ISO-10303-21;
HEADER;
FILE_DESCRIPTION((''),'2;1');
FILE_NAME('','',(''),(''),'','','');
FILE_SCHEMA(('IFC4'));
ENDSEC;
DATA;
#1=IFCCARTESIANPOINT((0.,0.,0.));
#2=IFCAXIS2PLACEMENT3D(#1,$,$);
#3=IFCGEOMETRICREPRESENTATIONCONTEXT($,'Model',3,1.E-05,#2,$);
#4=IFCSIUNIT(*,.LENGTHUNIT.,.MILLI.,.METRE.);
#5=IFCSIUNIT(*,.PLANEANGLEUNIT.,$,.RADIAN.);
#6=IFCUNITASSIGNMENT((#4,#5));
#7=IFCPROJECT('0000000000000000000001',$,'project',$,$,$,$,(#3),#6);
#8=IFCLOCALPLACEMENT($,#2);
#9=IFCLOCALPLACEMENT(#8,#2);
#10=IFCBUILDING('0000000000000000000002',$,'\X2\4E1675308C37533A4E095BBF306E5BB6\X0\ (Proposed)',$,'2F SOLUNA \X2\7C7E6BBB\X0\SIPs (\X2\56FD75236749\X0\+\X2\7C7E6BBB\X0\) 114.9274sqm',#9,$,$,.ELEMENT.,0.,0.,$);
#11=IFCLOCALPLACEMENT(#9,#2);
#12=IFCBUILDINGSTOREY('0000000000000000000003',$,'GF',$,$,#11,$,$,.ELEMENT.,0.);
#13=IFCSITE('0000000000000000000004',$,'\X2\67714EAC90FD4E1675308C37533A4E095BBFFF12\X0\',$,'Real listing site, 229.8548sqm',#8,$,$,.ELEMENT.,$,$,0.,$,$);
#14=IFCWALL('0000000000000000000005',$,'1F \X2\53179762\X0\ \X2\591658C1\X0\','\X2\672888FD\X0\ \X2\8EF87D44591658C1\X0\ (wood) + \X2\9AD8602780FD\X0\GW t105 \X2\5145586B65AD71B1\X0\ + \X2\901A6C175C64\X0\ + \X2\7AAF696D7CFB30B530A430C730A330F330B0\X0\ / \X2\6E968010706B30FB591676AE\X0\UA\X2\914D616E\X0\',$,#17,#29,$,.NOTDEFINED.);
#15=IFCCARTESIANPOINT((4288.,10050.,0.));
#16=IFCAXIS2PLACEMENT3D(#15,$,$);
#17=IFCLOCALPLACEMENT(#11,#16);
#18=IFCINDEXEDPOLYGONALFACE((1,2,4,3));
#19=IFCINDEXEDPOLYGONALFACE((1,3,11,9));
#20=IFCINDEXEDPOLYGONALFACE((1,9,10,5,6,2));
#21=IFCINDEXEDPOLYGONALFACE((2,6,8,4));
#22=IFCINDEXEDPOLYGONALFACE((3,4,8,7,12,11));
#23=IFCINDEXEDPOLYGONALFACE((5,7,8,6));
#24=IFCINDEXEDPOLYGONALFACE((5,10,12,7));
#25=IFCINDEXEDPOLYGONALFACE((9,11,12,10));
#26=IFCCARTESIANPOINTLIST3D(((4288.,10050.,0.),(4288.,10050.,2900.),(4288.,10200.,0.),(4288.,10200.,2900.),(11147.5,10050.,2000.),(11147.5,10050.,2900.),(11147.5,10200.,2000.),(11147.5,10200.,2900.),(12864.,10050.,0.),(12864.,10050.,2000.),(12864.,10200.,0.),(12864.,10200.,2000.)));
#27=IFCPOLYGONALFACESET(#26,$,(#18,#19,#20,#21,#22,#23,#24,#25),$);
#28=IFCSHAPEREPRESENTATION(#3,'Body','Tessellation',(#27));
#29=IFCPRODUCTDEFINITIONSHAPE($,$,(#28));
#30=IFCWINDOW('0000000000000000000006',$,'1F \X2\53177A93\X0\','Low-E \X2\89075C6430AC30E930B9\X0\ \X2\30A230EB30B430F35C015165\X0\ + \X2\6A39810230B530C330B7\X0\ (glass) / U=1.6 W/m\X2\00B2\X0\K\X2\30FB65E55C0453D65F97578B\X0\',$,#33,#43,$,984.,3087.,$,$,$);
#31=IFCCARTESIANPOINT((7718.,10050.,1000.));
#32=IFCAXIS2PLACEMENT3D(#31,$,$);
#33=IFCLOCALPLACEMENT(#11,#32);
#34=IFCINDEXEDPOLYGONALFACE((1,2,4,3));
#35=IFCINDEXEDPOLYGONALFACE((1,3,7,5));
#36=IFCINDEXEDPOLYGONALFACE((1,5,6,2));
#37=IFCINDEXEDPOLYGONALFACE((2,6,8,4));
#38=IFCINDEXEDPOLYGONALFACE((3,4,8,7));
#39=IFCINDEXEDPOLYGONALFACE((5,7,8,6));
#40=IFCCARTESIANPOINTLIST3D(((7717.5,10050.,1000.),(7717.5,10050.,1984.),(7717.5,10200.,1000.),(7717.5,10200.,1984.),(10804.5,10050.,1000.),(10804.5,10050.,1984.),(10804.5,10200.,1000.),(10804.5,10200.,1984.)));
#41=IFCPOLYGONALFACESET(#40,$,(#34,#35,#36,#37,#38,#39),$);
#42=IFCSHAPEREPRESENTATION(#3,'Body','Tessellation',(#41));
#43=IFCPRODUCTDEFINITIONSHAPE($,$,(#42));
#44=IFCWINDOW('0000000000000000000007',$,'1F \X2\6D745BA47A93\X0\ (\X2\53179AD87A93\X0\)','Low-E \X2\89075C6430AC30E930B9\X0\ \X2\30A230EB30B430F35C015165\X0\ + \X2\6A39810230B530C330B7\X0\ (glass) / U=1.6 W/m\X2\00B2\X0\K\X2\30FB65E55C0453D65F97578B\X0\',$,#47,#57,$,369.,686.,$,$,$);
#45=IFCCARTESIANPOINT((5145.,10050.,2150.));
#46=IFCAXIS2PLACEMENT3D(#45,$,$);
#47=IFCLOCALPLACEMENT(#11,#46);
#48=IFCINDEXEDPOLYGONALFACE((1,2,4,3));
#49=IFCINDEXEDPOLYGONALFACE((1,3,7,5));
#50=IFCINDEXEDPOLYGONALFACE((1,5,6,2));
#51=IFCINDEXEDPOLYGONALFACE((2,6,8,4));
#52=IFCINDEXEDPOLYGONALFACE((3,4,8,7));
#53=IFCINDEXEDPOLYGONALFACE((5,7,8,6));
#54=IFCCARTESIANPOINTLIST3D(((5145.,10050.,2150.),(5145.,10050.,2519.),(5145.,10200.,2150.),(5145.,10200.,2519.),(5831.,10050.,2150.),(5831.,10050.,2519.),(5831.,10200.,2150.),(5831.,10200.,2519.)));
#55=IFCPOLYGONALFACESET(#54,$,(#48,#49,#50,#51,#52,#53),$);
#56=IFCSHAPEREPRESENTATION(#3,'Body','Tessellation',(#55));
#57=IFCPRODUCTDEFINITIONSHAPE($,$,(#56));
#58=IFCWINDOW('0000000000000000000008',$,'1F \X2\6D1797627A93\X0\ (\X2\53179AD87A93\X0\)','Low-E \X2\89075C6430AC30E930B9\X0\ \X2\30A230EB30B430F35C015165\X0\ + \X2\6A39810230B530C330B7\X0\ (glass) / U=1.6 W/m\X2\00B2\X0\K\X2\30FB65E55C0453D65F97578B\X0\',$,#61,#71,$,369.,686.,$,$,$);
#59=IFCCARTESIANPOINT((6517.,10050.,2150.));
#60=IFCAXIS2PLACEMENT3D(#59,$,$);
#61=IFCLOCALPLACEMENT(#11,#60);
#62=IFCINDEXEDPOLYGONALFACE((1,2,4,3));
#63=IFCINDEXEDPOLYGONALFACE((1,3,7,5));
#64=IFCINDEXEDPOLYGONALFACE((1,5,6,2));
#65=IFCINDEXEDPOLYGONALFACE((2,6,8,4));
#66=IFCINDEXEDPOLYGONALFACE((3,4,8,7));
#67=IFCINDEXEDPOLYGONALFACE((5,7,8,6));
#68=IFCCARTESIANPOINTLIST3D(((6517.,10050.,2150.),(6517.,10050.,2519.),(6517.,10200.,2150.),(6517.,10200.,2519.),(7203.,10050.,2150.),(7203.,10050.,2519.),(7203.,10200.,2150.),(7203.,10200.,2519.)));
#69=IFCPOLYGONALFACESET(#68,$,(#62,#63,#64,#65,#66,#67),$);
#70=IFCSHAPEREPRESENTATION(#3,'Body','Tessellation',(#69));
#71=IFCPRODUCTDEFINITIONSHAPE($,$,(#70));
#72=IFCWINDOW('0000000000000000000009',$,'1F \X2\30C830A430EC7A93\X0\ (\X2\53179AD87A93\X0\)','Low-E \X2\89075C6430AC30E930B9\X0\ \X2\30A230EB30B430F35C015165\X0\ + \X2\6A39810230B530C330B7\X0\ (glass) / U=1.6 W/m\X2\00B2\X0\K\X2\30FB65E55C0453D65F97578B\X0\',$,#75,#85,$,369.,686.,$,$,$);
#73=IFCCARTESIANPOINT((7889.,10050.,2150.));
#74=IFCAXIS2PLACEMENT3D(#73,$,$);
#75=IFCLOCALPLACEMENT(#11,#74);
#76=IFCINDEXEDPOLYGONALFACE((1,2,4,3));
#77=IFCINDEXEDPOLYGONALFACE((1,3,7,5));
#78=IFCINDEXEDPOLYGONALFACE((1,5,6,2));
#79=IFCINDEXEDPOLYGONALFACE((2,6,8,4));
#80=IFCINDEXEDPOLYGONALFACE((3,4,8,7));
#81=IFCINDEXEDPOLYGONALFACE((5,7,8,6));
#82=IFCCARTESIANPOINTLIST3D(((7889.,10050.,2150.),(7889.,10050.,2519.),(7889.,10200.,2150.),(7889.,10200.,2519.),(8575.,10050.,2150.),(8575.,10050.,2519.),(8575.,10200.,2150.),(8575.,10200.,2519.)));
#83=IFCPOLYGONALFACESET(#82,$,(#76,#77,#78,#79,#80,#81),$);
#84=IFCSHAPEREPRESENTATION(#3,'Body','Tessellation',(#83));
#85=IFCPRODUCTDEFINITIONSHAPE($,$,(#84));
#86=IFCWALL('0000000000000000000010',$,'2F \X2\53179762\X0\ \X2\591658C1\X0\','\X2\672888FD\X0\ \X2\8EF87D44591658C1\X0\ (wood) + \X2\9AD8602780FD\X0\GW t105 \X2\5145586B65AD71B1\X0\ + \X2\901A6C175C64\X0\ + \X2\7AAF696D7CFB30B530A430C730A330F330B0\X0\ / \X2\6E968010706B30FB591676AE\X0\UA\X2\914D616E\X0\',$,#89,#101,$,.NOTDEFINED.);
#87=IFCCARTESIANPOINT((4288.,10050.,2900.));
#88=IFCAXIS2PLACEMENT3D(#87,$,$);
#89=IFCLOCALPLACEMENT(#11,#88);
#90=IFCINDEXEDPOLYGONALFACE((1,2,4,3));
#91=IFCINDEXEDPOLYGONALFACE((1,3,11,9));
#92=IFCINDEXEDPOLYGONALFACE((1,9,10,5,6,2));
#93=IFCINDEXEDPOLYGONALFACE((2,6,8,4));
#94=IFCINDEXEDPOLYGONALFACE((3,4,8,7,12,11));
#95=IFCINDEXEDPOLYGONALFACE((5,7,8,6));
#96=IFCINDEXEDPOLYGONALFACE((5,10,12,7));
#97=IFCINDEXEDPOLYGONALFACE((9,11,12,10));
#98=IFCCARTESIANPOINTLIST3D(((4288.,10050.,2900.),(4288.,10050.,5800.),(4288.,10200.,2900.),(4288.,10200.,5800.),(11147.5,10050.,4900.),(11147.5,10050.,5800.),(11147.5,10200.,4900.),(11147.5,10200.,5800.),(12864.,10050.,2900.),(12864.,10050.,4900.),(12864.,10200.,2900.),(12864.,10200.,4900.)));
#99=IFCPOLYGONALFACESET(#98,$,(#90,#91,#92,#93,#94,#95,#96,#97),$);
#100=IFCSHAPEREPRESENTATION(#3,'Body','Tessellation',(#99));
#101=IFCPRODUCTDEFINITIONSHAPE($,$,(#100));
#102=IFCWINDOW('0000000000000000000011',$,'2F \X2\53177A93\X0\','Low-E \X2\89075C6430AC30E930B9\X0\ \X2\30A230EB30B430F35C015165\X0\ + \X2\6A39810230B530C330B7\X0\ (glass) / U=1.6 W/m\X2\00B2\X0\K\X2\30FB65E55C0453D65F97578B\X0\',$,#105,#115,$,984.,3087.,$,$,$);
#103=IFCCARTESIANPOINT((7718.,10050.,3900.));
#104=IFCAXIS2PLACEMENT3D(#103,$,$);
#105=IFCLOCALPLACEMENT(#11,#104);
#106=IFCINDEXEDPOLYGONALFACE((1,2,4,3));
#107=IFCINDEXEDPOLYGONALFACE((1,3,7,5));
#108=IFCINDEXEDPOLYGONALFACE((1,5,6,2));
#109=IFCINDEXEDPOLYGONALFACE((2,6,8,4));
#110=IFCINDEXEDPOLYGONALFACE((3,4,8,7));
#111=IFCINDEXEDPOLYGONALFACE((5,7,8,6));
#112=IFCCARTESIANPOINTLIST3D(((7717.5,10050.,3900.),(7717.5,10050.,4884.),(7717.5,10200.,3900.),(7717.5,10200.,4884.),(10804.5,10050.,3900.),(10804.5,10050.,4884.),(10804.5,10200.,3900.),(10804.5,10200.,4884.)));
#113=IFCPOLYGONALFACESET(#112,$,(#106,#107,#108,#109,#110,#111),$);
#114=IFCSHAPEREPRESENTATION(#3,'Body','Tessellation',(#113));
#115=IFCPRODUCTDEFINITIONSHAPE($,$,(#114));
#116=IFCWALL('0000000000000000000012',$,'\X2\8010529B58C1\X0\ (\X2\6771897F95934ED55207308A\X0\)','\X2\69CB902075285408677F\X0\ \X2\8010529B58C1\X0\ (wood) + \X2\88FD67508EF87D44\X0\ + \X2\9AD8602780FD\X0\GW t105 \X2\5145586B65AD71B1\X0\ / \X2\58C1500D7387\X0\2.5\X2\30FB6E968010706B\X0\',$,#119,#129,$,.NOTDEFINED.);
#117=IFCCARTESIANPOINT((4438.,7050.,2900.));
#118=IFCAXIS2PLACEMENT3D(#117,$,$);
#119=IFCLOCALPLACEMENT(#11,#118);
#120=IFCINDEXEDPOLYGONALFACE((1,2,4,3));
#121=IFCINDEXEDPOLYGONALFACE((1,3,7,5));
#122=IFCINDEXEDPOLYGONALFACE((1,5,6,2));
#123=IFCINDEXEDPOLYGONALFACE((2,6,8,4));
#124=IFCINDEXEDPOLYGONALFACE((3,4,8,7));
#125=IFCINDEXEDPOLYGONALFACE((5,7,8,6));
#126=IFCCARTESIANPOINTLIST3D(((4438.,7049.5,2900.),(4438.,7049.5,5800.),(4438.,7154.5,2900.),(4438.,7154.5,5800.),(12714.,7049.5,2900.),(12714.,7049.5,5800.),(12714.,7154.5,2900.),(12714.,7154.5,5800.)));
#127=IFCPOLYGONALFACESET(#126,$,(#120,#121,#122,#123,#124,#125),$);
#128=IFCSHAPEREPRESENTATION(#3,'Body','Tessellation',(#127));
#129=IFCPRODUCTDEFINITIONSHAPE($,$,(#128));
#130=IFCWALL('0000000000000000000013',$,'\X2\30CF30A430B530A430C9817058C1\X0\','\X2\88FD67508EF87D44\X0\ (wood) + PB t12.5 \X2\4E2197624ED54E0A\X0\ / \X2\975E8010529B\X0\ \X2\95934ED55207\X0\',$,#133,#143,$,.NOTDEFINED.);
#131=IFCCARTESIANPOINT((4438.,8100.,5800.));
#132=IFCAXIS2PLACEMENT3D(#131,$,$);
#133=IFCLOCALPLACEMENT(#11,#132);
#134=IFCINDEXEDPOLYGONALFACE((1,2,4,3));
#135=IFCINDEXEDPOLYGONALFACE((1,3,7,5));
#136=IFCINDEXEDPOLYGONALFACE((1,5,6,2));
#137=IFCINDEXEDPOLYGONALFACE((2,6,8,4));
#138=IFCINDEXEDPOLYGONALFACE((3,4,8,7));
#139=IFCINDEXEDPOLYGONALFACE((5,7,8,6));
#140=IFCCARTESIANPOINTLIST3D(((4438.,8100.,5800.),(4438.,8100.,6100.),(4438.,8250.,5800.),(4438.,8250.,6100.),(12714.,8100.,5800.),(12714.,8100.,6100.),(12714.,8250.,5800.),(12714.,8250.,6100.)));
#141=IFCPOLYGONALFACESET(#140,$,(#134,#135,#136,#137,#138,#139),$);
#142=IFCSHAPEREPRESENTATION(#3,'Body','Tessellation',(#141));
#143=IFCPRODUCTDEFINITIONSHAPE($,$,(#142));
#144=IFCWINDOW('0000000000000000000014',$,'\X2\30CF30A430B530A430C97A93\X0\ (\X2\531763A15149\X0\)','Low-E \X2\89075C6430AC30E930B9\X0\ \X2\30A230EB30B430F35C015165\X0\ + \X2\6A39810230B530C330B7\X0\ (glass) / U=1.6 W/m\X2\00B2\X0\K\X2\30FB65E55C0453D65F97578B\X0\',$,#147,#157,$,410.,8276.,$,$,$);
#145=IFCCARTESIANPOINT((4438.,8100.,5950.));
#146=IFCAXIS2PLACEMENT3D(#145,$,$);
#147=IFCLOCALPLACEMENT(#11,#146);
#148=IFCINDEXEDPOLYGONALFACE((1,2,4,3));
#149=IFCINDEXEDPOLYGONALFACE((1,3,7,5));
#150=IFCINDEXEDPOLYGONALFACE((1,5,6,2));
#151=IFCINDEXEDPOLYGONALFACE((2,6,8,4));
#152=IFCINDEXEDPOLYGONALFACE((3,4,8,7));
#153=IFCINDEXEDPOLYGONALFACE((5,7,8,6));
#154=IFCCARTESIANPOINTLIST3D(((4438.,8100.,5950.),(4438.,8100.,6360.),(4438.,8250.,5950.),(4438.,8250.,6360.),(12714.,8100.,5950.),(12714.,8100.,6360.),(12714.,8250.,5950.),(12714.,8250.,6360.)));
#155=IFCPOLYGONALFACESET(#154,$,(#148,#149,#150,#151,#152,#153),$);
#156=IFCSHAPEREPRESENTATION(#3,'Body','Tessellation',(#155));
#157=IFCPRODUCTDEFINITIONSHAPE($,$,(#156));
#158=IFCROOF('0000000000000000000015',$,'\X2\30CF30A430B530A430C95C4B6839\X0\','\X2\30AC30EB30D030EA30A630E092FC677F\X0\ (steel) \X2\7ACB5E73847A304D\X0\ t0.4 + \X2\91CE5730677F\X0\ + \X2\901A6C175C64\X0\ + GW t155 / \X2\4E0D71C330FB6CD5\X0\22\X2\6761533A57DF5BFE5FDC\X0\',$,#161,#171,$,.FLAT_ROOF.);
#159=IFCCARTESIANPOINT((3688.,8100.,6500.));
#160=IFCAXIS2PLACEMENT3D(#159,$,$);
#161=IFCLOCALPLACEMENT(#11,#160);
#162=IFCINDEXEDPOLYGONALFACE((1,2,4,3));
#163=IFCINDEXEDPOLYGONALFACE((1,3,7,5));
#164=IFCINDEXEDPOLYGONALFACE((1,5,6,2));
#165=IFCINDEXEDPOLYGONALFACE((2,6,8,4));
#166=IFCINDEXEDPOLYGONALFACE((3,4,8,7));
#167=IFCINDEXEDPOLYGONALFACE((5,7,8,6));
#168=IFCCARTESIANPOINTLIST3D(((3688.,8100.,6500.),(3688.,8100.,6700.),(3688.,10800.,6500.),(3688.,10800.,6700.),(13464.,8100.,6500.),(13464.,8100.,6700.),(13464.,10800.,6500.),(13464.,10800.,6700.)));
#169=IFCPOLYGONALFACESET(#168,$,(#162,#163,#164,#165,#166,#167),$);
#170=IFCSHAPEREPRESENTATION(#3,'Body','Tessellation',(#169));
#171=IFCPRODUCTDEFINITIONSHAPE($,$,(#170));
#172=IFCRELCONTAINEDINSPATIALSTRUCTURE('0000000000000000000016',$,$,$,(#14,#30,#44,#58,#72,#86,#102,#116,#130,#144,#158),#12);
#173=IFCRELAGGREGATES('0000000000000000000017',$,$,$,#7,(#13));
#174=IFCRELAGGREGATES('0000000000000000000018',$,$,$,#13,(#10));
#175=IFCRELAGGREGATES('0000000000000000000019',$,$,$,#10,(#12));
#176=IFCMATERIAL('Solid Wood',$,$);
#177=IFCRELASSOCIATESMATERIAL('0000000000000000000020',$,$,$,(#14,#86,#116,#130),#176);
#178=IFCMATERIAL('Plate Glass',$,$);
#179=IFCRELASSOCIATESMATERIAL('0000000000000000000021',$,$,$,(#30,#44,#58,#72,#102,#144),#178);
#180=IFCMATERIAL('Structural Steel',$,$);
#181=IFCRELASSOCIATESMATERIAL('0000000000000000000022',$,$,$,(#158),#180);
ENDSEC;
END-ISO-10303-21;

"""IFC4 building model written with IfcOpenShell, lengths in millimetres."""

from ifc_helpers import new_model, si_unit, frame, frame_2d, origin, place, context, project, spatial, rectangle, extrude, material, element, fill, save


model = new_model("IFC4")

# Units and contexts
model_context = context("Model", 3, precision=1e-05, world=origin())
ifc_project = project(units=[si_unit("LENGTHUNIT", "METRE", prefix="MILLI"), si_unit("PLANEANGLEUNIT", "RADIAN")], contexts=[model_context])

# Site, building, storey
site_placement = place(None, origin())
site = spatial("IfcSite", under=ifc_project, at=site_placement, Name="東京都世田谷区三宿２", ObjectType="Real listing site, 229.8548sqm", CompositionType="ELEMENT", RefElevation=0.0)
building_placement = place(site_placement, origin())
building = spatial("IfcBuilding", under=site, at=building_placement, Name="世田谷区三宿の家 (Proposed)", ObjectType="2F SOLUNA 籾殻SIPs (国産杉+籾殻) 114.9274sqm", CompositionType="ELEMENT", ElevationOfRefHeight=0.0, ElevationOfTerrain=0.0)
storey_placement = place(building_placement, origin())
storey = spatial("IfcBuildingStorey", under=building, at=storey_placement, Name="GF", CompositionType="ELEMENT", Elevation=0.0)

# Wall, openings, windows
ifc_material_1 = material(Name="Solid Wood")
wall_1_placement = place(storey_placement, frame((4288.0, 10050.0, 0.0)))
wall_1 = element("IfcWall", 1, at=wall_1_placement, inside=storey, material=ifc_material_1, Name="1F 北面 外壁", Description="木製 軸組外壁 (wood) + 高性能GW t105 充填断熱 + 通気層 + 窯業系サイディング / 準耐火・外皮UA配慮", PredefinedType="NOTDEFINED", context=model_context, shape_type="SweptSolid", body=[
    extrude(rectangle(XDim=8576.0, YDim=150.0, at=frame_2d((4288.0, 75.0))), frame((4288.0, 10050.0, 0.0)), (0.0, 0.0, 1.0), 2900.0),
])
opening_1_placement = place(storey_placement, frame((7718.0, 10050.0, 1000.0)))
opening_1 = element("IfcOpeningElement", 2, at=opening_1_placement, cuts=wall_1, PredefinedType="NOTDEFINED", context=model_context, shape_type="SweptSolid", body=[
    extrude(rectangle(XDim=3087.0, YDim=150.0, at=frame_2d((1543.0, 75.0))), frame((7718.0, 10050.0, 1000.0)), (0.0, 0.0, 1.0), 984.0),
])
opening_2_placement = place(storey_placement, frame((5145.0, 10050.0, 2150.0)))
opening_2 = element("IfcOpeningElement", 3, at=opening_2_placement, cuts=wall_1, PredefinedType="NOTDEFINED", context=model_context, shape_type="SweptSolid", body=[
    extrude(rectangle(XDim=686.0, YDim=150.0, at=frame_2d((343.0, 75.0))), frame((5145.0, 10050.0, 2150.0)), (0.0, 0.0, 1.0), 369.0),
])
opening_3_placement = place(storey_placement, frame((6517.0, 10050.0, 2150.0)))
opening_3 = element("IfcOpeningElement", 4, at=opening_3_placement, cuts=wall_1, PredefinedType="NOTDEFINED", context=model_context, shape_type="SweptSolid", body=[
    extrude(rectangle(XDim=686.0, YDim=150.0, at=frame_2d((343.0, 75.0))), frame((6517.0, 10050.0, 2150.0)), (0.0, 0.0, 1.0), 369.0),
])
opening_4_placement = place(storey_placement, frame((7889.0, 10050.0, 2150.0)))
opening_4 = element("IfcOpeningElement", 5, at=opening_4_placement, cuts=wall_1, PredefinedType="NOTDEFINED", context=model_context, shape_type="SweptSolid", body=[
    extrude(rectangle(XDim=686.0, YDim=150.0, at=frame_2d((343.0, 75.0))), frame((7889.0, 10050.0, 2150.0)), (0.0, 0.0, 1.0), 369.0),
])
ifc_material_2 = material(Name="Plate Glass")
window_1_placement = place(storey_placement, frame((7718.0, 10050.0, 1000.0)))
window_1 = element("IfcWindow", 6, at=window_1_placement, inside=storey, material=ifc_material_2, Name="1F 北窓", Description="Low-E 複層ガラス アルゴン封入 + 樹脂サッシ (glass) / U=1.6 W/m²K・日射取得型", OverallHeight=984.0, OverallWidth=3087.0, context=model_context, shape_type="SweptSolid", body=[
    extrude(rectangle(XDim=3087.0, YDim=150.0, at=frame_2d((1543.0, 75.0))), frame((7718.0, 10050.0, 1000.0)), (0.0, 0.0, 1.0), 984.0),
])
fill(opening_1, window_1)
window_2_placement = place(storey_placement, frame((5145.0, 10050.0, 2150.0)))
window_2 = element("IfcWindow", 7, at=window_2_placement, inside=storey, material=ifc_material_2, Name="1F 浴室窓 (北高窓)", Description="Low-E 複層ガラス アルゴン封入 + 樹脂サッシ (glass) / U=1.6 W/m²K・日射取得型", OverallHeight=369.0, OverallWidth=686.0, context=model_context, shape_type="SweptSolid", body=[
    extrude(rectangle(XDim=686.0, YDim=150.0, at=frame_2d((343.0, 75.0))), frame((5145.0, 10050.0, 2150.0)), (0.0, 0.0, 1.0), 369.0),
])
fill(opening_2, window_2)
window_3_placement = place(storey_placement, frame((6517.0, 10050.0, 2150.0)))
window_3 = element("IfcWindow", 8, at=window_3_placement, inside=storey, material=ifc_material_2, Name="1F 洗面窓 (北高窓)", Description="Low-E 複層ガラス アルゴン封入 + 樹脂サッシ (glass) / U=1.6 W/m²K・日射取得型", OverallHeight=369.0, OverallWidth=686.0, context=model_context, shape_type="SweptSolid", body=[
    extrude(rectangle(XDim=686.0, YDim=150.0, at=frame_2d((343.0, 75.0))), frame((6517.0, 10050.0, 2150.0)), (0.0, 0.0, 1.0), 369.0),
])
fill(opening_3, window_3)
window_4_placement = place(storey_placement, frame((7889.0, 10050.0, 2150.0)))
window_4 = element("IfcWindow", 9, at=window_4_placement, inside=storey, material=ifc_material_2, Name="1F トイレ窓 (北高窓)", Description="Low-E 複層ガラス アルゴン封入 + 樹脂サッシ (glass) / U=1.6 W/m²K・日射取得型", OverallHeight=369.0, OverallWidth=686.0, context=model_context, shape_type="SweptSolid", body=[
    extrude(rectangle(XDim=686.0, YDim=150.0, at=frame_2d((343.0, 75.0))), frame((7889.0, 10050.0, 2150.0)), (0.0, 0.0, 1.0), 369.0),
])
fill(opening_4, window_4)

# Wall, opening, window
wall_2_placement = place(storey_placement, frame((4288.0, 10050.0, 2900.0)))
wall_2 = element("IfcWall", 10, at=wall_2_placement, inside=storey, material=ifc_material_1, Name="2F 北面 外壁", Description="木製 軸組外壁 (wood) + 高性能GW t105 充填断熱 + 通気層 + 窯業系サイディング / 準耐火・外皮UA配慮", PredefinedType="NOTDEFINED", context=model_context, shape_type="SweptSolid", body=[
    extrude(rectangle(XDim=8576.0, YDim=150.0, at=frame_2d((4288.0, 75.0))), frame((4288.0, 10050.0, 2900.0)), (0.0, 0.0, 1.0), 2900.0),
])
opening_5_placement = place(storey_placement, frame((7718.0, 10050.0, 3900.0)))
opening_5 = element("IfcOpeningElement", 11, at=opening_5_placement, cuts=wall_2, PredefinedType="NOTDEFINED", context=model_context, shape_type="SweptSolid", body=[
    extrude(rectangle(XDim=3087.0, YDim=150.0, at=frame_2d((1543.0, 75.0))), frame((7718.0, 10050.0, 3900.0)), (0.0, 0.0, 1.0), 984.0),
])
window_5_placement = place(storey_placement, frame((7718.0, 10050.0, 3900.0)))
window_5 = element("IfcWindow", 12, at=window_5_placement, inside=storey, material=ifc_material_2, Name="2F 北窓", Description="Low-E 複層ガラス アルゴン封入 + 樹脂サッシ (glass) / U=1.6 W/m²K・日射取得型", OverallHeight=984.0, OverallWidth=3087.0, context=model_context, shape_type="SweptSolid", body=[
    extrude(rectangle(XDim=3087.0, YDim=150.0, at=frame_2d((1543.0, 75.0))), frame((7718.0, 10050.0, 3900.0)), (0.0, 0.0, 1.0), 984.0),
])
fill(opening_5, window_5)

# Wall
wall_3_placement = place(storey_placement, frame((4438.0, 7050.0, 2900.0)))
element("IfcWall", 13, at=wall_3_placement, inside=storey, material=ifc_material_1, Name="耐力壁 (東西間仕切り)", Description="構造用合板 耐力壁 (wood) + 製材軸組 + 高性能GW t105 充填断熱 / 壁倍率2.5・準耐火", PredefinedType="NOTDEFINED", context=model_context, shape_type="SweptSolid", body=[
    extrude(rectangle(XDim=8276.0, YDim=105.0, at=frame_2d((4138.0, 52.0))), frame((4438.0, 7050.0, 2900.0)), (0.0, 0.0, 1.0), 2900.0),
])

# Wall, opening, window
wall_4_placement = place(storey_placement, frame((4438.0, 8100.0, 5800.0)))
wall_4 = element("IfcWall", 14, at=wall_4_placement, inside=storey, material=ifc_material_1, Name="ハイサイド腰壁", Description="製材軸組 (wood) + PB t12.5 両面仕上 / 非耐力 間仕切", PredefinedType="NOTDEFINED", context=model_context, shape_type="SweptSolid", body=[
    extrude(rectangle(XDim=8276.0, YDim=150.0, at=frame_2d((4138.0, 75.0))), frame((4438.0, 8100.0, 5800.0)), (0.0, 0.0, 1.0), 700.0),
])
opening_6_placement = place(storey_placement, frame((4438.0, 8100.0, 5950.0)))
opening_6 = element("IfcOpeningElement", 15, at=opening_6_placement, cuts=wall_4, PredefinedType="NOTDEFINED", context=model_context, shape_type="SweptSolid", body=[
    extrude(rectangle(XDim=8276.0, YDim=150.0, at=frame_2d((4138.0, 75.0))), frame((4438.0, 8100.0, 5950.0)), (0.0, 0.0, 1.0), 410.0),
])
window_6_placement = place(storey_placement, frame((4438.0, 8100.0, 5950.0)))
window_6 = element("IfcWindow", 16, at=window_6_placement, inside=storey, material=ifc_material_2, Name="ハイサイド窓 (北採光)", Description="Low-E 複層ガラス アルゴン封入 + 樹脂サッシ (glass) / U=1.6 W/m²K・日射取得型", OverallHeight=410.0, OverallWidth=8276.0, context=model_context, shape_type="SweptSolid", body=[
    extrude(rectangle(XDim=8276.0, YDim=150.0, at=frame_2d((4138.0, 75.0))), frame((4438.0, 8100.0, 5950.0)), (0.0, 0.0, 1.0), 410.0),
])
fill(opening_6, window_6)

# Roof
ifc_material_3 = material(Name="Structural Steel")
roof_placement = place(storey_placement, frame((3688.0, 8100.0, 6500.0)))
element("IfcRoof", 17, at=roof_placement, inside=storey, material=ifc_material_3, Name="ハイサイド屋根", Description="ガルバリウム鋼板 (steel) 立平葺き t0.4 + 野地板 + 通気層 + GW t155 / 不燃・法22条区域対応", PredefinedType="FLAT_ROOF", context=model_context, shape_type="SweptSolid", body=[
    extrude(rectangle(XDim=9776.0, YDim=2700.0, at=frame_2d((4888.0, 1350.0))), frame((3688.0, 8100.0, 6500.0)), (0.0, 0.0, 1.0), 200.0),
])

save(model, "model.ifc")
